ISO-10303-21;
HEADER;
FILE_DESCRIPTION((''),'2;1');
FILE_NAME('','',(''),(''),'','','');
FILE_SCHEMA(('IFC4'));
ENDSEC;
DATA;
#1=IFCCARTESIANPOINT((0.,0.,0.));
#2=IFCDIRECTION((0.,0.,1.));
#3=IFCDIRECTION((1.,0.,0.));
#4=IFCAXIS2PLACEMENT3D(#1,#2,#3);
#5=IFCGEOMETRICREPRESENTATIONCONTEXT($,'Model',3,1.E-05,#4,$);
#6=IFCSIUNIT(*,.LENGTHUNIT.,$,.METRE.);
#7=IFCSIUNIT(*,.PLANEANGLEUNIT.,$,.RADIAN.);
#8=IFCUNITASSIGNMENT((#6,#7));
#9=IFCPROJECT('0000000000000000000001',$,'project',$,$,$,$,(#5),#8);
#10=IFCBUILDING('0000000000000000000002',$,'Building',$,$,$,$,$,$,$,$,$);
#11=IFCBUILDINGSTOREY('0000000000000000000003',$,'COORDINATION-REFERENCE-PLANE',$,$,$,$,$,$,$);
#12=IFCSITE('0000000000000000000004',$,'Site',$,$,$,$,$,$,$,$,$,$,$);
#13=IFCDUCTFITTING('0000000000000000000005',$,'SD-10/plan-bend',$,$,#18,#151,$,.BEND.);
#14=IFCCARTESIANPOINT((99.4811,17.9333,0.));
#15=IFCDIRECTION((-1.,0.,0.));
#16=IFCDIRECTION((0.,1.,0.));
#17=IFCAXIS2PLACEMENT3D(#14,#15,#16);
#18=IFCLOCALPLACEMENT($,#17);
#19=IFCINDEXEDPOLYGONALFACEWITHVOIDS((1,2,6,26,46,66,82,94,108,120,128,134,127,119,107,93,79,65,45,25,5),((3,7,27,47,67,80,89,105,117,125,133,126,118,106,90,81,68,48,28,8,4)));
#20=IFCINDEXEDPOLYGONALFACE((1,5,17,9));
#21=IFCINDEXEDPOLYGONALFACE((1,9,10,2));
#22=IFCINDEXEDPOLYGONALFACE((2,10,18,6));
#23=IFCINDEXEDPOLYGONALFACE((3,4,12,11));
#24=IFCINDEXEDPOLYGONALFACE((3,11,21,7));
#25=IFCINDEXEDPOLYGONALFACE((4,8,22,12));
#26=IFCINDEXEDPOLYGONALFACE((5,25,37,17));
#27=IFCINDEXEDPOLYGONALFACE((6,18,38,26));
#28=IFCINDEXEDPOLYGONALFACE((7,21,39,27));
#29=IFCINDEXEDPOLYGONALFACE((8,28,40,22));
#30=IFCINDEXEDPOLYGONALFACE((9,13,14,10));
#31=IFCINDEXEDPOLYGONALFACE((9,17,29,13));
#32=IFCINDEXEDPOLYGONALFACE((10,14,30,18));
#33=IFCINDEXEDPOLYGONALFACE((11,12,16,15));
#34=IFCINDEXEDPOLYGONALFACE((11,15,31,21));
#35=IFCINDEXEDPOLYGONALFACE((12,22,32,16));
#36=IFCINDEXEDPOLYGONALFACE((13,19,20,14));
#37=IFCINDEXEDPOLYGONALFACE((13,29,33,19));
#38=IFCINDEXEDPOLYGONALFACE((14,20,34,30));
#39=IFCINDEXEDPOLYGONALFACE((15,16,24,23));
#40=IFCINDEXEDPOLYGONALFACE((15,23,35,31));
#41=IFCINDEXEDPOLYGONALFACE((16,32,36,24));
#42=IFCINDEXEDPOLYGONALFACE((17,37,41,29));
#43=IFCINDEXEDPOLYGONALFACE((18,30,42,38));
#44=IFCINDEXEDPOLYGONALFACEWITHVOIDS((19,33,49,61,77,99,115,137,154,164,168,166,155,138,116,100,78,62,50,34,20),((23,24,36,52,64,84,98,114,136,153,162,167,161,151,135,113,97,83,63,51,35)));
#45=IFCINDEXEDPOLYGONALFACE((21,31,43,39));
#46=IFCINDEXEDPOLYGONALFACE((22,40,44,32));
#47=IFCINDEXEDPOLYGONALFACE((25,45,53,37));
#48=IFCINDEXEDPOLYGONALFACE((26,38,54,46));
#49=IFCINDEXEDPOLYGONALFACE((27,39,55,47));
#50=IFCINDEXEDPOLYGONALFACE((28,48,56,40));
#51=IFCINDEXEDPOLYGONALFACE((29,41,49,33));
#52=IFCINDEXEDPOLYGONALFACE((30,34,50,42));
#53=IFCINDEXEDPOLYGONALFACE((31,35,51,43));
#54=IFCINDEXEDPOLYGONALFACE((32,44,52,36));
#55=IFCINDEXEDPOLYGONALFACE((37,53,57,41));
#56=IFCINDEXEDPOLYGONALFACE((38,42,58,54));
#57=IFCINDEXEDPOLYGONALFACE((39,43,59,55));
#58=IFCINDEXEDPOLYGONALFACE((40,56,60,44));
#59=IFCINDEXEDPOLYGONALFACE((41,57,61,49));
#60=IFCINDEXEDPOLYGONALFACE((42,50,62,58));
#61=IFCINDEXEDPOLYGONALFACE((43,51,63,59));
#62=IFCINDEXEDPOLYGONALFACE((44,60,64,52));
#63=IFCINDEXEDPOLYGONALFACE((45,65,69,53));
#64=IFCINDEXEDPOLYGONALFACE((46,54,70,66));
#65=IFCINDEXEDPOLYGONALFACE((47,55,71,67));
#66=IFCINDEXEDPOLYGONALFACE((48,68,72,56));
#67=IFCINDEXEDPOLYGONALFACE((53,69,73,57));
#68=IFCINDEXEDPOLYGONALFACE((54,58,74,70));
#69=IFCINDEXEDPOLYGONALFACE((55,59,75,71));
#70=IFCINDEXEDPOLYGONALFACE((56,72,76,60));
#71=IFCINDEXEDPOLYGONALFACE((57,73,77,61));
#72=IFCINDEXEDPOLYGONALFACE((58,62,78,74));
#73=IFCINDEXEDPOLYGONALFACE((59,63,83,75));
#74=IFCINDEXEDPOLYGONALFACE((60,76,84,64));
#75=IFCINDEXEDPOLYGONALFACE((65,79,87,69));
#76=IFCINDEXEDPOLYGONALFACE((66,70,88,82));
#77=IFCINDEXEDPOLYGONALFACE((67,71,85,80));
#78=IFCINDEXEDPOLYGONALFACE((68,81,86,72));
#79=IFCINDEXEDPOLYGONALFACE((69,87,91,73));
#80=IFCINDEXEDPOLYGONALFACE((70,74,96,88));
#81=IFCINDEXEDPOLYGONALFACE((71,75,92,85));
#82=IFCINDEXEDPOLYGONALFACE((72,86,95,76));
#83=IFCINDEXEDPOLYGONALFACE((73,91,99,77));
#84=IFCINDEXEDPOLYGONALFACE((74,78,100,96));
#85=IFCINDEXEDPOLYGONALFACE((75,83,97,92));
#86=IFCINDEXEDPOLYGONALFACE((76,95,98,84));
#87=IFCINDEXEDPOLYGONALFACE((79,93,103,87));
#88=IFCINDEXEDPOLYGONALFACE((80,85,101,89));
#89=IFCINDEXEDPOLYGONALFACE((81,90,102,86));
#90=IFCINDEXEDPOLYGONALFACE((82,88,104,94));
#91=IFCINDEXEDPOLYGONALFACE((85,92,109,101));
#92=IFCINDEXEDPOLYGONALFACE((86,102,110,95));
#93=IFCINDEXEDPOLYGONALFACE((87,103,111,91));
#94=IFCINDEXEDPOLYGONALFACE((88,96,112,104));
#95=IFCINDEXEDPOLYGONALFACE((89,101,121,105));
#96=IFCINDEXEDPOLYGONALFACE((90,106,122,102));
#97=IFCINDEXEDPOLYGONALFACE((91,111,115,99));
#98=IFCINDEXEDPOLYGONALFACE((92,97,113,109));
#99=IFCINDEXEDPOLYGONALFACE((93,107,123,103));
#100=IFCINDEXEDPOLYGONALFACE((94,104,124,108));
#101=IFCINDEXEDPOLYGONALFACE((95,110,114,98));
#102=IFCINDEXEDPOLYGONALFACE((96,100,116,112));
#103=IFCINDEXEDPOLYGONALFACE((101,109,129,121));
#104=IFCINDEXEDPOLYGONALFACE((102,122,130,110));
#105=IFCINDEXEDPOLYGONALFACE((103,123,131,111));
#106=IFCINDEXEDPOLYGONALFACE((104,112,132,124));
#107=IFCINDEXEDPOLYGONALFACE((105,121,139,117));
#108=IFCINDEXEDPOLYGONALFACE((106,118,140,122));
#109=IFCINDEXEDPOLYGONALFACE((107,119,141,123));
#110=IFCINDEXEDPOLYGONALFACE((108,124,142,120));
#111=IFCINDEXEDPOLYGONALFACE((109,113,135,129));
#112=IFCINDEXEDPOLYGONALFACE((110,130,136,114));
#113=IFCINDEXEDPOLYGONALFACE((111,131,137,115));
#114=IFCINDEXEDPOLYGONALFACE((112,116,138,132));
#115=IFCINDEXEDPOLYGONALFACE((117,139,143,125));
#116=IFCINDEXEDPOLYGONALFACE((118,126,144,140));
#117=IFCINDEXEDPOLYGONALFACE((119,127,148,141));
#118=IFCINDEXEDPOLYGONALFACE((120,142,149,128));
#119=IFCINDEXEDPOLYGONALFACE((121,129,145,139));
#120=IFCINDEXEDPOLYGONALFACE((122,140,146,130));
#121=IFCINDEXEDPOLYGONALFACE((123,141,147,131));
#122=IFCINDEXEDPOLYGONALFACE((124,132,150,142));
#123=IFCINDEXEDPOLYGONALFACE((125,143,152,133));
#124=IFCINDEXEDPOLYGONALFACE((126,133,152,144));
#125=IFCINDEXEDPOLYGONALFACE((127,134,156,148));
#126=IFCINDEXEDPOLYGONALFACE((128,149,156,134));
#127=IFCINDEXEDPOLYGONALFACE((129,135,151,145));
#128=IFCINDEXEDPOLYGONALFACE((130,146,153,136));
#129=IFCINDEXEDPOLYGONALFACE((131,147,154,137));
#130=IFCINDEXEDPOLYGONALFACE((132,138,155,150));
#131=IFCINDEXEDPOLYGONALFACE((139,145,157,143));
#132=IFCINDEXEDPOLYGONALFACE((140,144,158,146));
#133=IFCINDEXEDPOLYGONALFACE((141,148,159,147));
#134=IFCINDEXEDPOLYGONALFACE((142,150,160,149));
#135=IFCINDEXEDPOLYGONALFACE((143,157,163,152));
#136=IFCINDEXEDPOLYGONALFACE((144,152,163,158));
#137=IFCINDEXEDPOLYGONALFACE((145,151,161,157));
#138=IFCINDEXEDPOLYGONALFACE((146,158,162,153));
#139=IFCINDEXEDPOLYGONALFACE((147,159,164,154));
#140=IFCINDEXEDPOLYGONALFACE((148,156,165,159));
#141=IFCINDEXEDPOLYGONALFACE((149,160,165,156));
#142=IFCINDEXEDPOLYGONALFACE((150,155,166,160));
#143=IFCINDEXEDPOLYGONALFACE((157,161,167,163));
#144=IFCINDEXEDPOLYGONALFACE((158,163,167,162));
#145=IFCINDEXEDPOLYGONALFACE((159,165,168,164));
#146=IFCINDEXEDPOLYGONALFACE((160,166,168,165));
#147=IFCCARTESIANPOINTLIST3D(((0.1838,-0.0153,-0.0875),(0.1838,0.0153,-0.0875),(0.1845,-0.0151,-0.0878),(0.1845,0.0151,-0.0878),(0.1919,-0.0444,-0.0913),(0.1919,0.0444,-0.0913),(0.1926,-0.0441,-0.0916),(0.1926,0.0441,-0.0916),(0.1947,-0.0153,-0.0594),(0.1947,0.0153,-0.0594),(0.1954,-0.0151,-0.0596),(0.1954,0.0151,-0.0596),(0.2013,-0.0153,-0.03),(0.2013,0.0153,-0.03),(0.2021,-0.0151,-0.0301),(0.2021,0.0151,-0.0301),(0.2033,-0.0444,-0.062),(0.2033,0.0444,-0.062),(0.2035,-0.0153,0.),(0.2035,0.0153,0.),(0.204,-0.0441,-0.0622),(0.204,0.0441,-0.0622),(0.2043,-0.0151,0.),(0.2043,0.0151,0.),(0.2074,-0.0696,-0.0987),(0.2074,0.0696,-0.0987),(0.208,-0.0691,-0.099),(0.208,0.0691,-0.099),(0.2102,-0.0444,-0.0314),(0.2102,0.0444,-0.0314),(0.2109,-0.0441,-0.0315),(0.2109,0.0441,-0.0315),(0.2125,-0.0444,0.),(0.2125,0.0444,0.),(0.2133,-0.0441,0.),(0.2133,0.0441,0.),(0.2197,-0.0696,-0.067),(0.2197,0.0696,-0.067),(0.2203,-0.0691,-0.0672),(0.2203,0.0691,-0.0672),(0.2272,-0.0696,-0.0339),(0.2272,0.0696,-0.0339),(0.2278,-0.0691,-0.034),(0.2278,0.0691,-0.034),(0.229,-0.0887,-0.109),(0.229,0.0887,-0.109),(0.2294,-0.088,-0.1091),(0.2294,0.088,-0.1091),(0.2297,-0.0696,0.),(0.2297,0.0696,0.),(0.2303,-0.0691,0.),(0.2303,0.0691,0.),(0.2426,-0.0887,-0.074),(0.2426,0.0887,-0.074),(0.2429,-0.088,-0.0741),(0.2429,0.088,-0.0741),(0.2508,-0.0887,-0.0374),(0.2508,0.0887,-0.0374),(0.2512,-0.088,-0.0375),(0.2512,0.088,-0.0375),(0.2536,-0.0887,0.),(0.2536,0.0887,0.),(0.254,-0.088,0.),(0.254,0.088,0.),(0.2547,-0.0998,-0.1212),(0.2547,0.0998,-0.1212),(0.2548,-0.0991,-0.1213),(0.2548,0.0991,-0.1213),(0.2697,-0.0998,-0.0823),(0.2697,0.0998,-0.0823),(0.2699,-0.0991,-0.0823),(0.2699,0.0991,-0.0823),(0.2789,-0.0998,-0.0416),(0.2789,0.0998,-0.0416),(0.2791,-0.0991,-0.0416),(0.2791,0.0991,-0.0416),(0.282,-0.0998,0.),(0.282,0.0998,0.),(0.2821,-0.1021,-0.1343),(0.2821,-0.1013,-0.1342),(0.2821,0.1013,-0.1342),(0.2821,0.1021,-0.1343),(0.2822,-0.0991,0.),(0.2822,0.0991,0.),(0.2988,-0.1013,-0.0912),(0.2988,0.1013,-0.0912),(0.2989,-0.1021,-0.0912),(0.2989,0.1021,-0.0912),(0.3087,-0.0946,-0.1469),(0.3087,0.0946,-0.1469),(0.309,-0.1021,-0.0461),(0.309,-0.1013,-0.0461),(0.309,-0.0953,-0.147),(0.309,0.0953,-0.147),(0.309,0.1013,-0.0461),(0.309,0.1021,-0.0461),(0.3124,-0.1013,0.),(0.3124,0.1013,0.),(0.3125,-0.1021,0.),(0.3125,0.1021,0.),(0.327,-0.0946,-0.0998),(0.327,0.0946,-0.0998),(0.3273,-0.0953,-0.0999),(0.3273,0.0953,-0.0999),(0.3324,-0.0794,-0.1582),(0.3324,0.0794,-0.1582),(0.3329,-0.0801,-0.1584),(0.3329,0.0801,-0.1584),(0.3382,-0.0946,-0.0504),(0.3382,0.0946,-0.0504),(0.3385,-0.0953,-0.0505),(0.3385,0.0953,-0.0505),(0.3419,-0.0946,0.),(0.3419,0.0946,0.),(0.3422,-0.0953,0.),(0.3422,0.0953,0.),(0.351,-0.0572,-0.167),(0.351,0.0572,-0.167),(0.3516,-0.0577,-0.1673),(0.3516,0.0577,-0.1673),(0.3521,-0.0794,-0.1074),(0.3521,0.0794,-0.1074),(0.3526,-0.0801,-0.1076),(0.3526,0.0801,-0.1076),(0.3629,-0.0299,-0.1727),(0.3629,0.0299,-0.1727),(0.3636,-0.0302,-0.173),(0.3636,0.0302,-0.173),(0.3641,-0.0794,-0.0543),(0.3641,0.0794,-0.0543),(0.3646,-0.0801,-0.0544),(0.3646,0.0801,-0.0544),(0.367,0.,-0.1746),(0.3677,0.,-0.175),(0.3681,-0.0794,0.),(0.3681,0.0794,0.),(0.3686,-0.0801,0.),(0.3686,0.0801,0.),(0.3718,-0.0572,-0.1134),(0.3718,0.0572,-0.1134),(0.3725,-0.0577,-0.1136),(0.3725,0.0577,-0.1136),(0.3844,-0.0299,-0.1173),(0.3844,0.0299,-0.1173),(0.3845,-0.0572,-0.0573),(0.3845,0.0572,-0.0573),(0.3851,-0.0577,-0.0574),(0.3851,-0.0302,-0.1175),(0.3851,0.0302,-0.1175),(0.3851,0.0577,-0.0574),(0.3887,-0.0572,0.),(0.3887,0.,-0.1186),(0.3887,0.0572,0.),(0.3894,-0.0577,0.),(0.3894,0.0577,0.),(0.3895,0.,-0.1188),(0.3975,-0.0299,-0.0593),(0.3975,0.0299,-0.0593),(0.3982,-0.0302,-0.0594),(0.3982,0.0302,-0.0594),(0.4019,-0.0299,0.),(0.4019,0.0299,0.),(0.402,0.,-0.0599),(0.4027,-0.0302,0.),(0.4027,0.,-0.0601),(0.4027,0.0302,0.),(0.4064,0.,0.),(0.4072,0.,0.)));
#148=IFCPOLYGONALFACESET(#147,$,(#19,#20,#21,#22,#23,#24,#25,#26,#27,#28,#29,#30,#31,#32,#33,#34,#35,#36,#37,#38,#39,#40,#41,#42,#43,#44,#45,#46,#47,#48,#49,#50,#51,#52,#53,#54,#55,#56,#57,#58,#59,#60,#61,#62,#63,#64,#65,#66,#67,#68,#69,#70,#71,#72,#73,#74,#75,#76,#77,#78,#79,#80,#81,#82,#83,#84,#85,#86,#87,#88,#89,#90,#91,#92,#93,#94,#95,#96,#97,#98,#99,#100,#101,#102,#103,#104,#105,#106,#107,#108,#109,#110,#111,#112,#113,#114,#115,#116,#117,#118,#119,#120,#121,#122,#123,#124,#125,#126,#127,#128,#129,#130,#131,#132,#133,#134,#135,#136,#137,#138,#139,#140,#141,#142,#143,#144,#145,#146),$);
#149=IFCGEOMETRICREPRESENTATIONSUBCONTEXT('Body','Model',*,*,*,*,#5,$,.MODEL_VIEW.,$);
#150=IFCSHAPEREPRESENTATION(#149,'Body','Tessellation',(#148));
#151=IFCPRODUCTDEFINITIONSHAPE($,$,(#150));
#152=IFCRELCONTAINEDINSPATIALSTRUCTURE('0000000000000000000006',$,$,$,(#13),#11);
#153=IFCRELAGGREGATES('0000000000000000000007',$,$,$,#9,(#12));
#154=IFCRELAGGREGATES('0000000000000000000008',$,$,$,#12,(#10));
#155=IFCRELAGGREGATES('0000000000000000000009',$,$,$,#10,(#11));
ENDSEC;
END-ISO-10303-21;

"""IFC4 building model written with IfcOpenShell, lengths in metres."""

from ifc_helpers import new_model, entity, si_unit, frame, origin_with_axes, place, context, subcontext, project, spatial, element, save


model = new_model("IFC4")

# Units and contexts
model_context_1 = context("Model", 3, precision=1e-05, world=origin_with_axes())
body_context_1 = subcontext(model_context_1, "Body", "Model", "MODEL_VIEW")
ifc_project = project(units=[si_unit("LENGTHUNIT", "METRE"), si_unit("PLANEANGLEUNIT", "RADIAN")], contexts=[model_context_1])

# Site, building, storey
site = spatial("IfcSite", under=ifc_project, Name="Site")
building = spatial("IfcBuilding", under=site, Name="Building")
storey = spatial("IfcBuildingStorey", under=building, Name="COORDINATION-REFERENCE-PLANE")

# Duct fitting
duct_fitting_1_placement = place(None, frame((99.4811, 17.9333, 0.0), z_axis=(-1.0, 0.0, 0.0), x_axis=(0.0, 1.0, 0.0)))
element("IfcDuctFitting", 1, at=duct_fitting_1_placement, inside=storey, Name="SD-10/plan-bend", PredefinedType="BEND", context=body_context_1, shape_type="SweptSolid", body=[
    entity("IfcRevolvedAreaSolid", entity("IfcCircleHollowProfileDef", "AREA", None, entity("IfcAxis2Placement2D", entity("IfcCartesianPoint", [0.3048, 0.0])), 0.1024, 0.0008), entity("IfcAxis2Placement3D", entity("IfcCartesianPoint", [0.0, 0.0, 0.0]), entity("IfcDirection", [0.0, 0.0, 1.0]), entity("IfcDirection", [1.0, 0.0, 0.0])), entity("IfcAxis1Placement", entity("IfcCartesianPoint", [0.0, 0.0, 0.0]), entity("IfcDirection", [0.0, 1.0, 0.0])), 0.444153),
])

save(model, "model.ifc")
